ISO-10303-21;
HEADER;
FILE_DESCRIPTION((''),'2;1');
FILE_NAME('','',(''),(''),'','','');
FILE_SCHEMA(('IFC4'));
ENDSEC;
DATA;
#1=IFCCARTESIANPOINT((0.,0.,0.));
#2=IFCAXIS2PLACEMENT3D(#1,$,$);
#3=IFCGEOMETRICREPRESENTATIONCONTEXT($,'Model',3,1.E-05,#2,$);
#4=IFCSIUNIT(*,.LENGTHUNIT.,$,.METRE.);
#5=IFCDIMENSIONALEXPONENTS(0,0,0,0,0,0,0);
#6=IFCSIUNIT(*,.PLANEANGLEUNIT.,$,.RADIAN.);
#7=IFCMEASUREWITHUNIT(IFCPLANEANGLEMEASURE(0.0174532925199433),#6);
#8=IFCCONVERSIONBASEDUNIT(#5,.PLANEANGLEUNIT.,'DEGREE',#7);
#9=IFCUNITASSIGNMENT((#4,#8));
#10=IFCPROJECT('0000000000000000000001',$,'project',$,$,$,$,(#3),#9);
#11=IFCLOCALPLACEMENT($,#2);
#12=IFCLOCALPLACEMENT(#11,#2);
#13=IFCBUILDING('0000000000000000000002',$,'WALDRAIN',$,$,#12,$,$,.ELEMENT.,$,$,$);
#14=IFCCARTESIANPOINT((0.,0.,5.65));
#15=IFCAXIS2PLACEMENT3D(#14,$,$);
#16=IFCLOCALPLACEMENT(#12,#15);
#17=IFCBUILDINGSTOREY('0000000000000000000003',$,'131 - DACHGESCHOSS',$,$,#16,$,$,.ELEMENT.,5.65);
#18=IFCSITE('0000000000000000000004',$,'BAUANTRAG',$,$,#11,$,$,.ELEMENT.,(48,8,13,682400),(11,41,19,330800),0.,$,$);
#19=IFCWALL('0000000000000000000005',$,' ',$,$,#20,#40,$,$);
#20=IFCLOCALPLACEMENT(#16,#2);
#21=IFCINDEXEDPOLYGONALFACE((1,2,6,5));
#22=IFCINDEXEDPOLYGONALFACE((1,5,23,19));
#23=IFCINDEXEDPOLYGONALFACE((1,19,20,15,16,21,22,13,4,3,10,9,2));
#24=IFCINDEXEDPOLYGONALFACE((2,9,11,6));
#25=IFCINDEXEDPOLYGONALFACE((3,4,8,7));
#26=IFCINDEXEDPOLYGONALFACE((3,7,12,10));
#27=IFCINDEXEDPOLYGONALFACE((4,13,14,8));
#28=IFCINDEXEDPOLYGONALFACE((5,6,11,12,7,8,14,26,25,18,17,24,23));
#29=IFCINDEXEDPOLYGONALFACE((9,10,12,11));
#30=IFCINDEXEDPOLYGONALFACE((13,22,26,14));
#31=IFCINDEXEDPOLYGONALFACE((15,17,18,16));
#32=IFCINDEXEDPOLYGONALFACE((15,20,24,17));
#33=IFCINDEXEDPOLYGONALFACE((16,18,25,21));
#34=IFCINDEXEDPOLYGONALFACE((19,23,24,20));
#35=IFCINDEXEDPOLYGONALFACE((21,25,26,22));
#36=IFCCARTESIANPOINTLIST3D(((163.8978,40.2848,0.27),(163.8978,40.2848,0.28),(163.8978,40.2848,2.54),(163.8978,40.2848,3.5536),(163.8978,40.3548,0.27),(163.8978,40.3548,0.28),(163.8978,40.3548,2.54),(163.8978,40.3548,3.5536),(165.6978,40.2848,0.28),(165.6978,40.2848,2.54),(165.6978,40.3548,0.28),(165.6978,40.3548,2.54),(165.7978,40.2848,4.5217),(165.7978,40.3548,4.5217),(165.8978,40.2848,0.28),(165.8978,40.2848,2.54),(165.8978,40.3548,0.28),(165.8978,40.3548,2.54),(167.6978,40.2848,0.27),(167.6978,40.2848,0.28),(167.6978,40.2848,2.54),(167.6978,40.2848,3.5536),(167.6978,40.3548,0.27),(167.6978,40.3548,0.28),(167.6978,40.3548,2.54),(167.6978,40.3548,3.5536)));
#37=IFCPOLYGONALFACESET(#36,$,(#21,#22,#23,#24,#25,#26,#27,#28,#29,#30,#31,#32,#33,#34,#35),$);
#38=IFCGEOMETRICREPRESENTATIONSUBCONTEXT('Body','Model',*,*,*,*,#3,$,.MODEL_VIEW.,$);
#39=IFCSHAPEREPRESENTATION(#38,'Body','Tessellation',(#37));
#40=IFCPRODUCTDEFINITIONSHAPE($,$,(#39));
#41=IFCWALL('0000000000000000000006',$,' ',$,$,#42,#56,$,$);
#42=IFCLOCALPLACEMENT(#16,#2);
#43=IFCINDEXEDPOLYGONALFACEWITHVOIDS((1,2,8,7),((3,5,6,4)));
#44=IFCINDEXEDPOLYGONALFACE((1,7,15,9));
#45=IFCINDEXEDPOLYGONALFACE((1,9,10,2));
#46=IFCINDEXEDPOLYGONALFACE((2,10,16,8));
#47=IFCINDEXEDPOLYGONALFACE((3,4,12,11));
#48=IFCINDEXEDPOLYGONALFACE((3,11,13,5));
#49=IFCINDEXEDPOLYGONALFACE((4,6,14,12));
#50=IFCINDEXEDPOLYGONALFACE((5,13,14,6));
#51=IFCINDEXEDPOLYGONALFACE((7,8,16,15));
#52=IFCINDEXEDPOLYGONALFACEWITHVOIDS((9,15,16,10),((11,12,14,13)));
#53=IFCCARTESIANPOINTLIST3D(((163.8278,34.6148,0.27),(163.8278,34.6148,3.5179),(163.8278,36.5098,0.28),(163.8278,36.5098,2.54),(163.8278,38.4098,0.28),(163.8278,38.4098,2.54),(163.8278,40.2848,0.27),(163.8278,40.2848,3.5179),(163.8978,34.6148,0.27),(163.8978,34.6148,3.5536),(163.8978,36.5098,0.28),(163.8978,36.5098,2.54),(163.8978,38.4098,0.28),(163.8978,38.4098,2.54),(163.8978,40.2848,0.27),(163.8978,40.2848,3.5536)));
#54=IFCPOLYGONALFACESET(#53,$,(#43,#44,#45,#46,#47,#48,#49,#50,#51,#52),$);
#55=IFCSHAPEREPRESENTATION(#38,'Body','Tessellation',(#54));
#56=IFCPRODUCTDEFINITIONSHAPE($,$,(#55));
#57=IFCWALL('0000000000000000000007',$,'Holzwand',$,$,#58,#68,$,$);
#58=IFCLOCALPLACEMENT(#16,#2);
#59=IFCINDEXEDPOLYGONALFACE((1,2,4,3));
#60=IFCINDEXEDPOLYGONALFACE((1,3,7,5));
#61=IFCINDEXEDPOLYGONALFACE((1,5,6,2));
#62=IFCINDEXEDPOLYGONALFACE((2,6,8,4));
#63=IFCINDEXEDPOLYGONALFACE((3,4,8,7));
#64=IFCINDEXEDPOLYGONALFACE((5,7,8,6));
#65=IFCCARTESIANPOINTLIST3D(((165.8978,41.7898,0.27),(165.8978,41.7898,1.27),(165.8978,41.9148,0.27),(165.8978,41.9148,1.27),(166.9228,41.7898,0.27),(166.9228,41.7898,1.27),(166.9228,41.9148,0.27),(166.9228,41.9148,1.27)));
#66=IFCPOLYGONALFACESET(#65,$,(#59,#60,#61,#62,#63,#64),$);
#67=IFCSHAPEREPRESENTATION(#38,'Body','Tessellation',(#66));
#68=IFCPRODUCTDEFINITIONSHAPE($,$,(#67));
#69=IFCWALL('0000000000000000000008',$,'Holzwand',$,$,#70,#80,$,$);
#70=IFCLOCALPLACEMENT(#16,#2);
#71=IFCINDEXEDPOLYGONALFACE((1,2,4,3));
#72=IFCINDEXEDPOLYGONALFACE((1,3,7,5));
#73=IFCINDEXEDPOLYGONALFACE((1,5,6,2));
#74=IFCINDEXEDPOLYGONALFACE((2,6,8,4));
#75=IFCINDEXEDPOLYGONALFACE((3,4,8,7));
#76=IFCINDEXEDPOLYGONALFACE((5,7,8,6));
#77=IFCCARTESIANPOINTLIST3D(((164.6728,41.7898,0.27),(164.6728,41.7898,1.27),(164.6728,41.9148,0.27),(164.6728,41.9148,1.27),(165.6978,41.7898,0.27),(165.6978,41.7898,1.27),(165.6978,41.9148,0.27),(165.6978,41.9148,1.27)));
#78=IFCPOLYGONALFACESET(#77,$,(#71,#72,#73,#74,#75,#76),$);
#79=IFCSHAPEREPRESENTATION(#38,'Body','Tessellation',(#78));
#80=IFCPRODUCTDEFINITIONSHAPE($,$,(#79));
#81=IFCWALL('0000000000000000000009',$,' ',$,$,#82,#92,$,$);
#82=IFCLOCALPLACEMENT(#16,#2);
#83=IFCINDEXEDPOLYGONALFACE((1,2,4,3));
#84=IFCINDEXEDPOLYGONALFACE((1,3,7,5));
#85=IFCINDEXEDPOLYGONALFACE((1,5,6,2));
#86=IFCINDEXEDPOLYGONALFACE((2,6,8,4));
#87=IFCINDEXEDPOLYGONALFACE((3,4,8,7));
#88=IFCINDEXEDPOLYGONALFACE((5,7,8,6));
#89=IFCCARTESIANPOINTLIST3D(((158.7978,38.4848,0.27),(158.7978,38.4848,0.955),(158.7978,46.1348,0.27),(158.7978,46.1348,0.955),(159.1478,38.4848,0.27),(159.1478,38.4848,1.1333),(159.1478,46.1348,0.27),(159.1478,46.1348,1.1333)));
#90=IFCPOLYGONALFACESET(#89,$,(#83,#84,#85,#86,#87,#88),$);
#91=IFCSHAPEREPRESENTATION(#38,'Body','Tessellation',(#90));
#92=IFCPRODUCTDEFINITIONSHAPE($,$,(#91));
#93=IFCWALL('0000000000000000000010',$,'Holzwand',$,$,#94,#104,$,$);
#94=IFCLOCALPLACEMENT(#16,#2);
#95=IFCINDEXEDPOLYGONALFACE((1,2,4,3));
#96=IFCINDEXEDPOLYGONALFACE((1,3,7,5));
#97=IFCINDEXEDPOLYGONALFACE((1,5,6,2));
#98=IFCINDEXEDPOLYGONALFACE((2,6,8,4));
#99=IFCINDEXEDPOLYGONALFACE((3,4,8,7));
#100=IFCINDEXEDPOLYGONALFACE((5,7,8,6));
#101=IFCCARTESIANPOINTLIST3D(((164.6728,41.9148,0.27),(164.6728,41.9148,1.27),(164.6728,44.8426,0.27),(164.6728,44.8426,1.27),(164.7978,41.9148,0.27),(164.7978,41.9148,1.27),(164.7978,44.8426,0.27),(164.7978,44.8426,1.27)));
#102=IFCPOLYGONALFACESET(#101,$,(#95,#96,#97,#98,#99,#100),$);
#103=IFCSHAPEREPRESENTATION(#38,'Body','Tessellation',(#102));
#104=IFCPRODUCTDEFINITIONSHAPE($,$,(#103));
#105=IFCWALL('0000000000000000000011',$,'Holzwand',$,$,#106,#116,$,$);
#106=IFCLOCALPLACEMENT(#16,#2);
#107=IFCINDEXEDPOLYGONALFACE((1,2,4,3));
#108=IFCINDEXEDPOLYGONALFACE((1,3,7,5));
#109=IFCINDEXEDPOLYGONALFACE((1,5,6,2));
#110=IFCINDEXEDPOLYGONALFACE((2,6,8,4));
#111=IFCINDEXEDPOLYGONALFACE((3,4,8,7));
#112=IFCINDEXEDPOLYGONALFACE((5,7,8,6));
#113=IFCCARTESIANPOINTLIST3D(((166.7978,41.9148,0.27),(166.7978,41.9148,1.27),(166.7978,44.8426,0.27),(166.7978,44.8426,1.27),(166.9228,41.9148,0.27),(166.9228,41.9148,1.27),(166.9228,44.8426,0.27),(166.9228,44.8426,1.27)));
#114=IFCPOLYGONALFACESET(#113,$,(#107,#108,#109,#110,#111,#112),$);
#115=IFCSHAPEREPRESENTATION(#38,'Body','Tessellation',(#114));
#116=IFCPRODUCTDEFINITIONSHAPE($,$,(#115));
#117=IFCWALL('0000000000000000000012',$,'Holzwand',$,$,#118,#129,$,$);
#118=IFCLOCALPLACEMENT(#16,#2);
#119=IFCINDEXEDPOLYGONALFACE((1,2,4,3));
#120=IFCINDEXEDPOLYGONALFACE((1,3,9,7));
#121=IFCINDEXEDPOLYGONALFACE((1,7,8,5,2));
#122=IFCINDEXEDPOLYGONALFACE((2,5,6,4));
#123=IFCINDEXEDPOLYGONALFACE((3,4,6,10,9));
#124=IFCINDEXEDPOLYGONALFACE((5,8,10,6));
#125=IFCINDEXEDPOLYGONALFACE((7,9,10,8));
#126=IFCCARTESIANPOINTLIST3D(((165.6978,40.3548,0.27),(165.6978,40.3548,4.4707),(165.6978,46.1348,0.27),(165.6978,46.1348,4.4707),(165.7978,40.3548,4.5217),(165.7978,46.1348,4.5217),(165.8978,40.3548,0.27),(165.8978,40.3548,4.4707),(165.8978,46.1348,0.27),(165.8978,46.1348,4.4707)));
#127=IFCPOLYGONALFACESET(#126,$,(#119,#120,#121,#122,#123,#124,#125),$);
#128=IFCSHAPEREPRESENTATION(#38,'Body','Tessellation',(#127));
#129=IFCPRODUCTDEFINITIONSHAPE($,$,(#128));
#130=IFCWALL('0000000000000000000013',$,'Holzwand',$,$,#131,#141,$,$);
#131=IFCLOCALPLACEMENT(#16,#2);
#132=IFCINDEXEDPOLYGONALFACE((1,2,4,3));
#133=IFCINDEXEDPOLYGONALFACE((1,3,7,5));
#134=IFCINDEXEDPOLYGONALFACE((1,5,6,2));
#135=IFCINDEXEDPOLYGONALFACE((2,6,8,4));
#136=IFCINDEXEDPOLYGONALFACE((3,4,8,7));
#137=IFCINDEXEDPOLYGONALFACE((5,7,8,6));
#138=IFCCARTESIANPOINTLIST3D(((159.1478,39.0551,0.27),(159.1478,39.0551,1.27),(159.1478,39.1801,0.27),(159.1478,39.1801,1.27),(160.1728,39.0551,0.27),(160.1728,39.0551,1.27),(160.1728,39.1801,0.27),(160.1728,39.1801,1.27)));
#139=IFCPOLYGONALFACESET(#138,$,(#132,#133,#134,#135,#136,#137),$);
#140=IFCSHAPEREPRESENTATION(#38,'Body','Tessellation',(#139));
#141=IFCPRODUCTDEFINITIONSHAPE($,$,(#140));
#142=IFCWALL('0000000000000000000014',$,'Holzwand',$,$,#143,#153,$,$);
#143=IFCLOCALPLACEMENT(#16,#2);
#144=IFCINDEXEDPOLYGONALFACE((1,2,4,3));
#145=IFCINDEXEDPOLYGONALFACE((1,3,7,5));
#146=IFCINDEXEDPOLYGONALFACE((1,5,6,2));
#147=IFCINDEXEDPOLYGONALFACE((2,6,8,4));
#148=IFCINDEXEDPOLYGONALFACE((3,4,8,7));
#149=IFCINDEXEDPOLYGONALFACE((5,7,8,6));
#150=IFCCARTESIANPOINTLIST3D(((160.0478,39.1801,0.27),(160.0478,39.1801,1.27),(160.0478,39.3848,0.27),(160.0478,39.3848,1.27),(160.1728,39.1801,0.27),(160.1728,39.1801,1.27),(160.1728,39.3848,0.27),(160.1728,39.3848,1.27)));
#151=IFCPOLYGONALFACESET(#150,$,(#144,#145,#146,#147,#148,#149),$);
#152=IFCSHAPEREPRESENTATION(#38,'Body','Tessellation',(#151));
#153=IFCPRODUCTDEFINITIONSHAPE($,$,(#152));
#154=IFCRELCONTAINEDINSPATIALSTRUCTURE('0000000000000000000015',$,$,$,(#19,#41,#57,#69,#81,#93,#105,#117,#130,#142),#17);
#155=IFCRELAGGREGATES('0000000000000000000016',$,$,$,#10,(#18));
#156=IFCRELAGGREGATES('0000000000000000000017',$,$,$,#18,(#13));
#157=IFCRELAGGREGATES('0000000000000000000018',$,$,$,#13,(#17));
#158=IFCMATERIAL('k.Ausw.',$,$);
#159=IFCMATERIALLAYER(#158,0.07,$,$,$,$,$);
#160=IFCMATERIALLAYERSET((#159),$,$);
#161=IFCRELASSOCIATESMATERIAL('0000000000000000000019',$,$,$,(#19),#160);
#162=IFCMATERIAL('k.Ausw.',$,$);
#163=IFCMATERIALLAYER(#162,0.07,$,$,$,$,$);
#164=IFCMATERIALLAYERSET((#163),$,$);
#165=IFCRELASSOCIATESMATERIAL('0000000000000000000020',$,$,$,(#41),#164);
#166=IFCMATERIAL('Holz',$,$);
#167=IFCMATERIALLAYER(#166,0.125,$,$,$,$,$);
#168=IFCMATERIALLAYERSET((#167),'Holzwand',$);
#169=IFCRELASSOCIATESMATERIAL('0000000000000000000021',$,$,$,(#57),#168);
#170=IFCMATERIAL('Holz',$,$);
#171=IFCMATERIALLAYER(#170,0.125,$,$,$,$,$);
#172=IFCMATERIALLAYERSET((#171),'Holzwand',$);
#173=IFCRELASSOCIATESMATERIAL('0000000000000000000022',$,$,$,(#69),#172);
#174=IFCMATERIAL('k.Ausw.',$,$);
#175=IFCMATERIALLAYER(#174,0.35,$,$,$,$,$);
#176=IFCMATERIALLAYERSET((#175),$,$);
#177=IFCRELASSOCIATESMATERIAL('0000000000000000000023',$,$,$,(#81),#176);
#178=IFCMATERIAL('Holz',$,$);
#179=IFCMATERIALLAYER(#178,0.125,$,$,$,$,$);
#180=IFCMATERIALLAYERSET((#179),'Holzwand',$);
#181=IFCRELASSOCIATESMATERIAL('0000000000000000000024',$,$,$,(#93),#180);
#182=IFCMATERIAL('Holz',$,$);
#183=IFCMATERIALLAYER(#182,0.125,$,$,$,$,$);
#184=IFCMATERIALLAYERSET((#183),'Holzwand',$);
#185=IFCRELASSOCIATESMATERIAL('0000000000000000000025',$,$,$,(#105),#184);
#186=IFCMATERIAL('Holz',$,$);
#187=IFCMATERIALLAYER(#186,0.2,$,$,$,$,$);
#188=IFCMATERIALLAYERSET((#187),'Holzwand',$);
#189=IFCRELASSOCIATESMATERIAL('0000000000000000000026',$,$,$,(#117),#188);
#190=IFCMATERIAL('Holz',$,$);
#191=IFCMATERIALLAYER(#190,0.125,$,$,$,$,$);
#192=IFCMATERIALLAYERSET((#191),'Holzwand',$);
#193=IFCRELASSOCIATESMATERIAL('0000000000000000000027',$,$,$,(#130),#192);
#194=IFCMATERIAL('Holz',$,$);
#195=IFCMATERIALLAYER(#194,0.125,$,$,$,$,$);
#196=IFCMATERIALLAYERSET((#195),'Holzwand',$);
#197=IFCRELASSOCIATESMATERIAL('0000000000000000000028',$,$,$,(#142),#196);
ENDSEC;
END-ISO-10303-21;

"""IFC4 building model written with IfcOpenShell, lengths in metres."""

from ifc_helpers import new_model, entity, si_unit, converted_unit, frame, frame_2d, origin, origin_with_axes, place, context, subcontext, project, spatial, polyline, rectangle, outline, extrude, clip, halfspace, bounded_halfspace, material, layer, layer_set, layer_usage, element, save


model = new_model("IFC4")

# Units and contexts
model_context = context("Model", 3, precision=1e-05, world=origin())
body_context = subcontext(model_context, "Body", "Model", "MODEL_VIEW")
ifc_project = project(units=[si_unit("LENGTHUNIT", "METRE"), converted_unit("PLANEANGLEUNIT", "DEGREE", entity("IfcPlaneAngleMeasure", 0.0174532925199433), si_unit("PLANEANGLEUNIT", "RADIAN"), dimensions=[0, 0, 0, 0, 0, 0, 0])], contexts=[model_context])

# Site, building, storey
site_placement = place(None, origin())
site = spatial("IfcSite", under=ifc_project, at=site_placement, Name="BAUANTRAG", CompositionType="ELEMENT", RefLatitude=(48, 8, 13, 682400), RefLongitude=(11, 41, 19, 330800), RefElevation=0.0)
building_placement = place(site_placement, origin())
building = spatial("IfcBuilding", under=site, at=building_placement, Name="WALDRAIN", CompositionType="ELEMENT")
storey_placement = place(building_placement, frame((0.0, 0.0, 5.65)))
storey = spatial("IfcBuildingStorey", under=building, at=storey_placement, Name="131 - DACHGESCHOSS", CompositionType="ELEMENT", Elevation=5.65)

# Wall, openings
ifc_material_1 = material(Name="k.Ausw.")
ifc_layer_1 = layer(ifc_material_1, 0.07)
ifc_layer_set_1 = layer_set([ifc_layer_1])
ifc_layer_usage_1 = layer_usage(ifc_layer_set_1, "AXIS2", "POSITIVE", 0.0)
wall_1_placement = place(storey_placement, frame((167.6978, 40.3548, 0.27), z_axis=(0.0, 0.0, 1.0), x_axis=(-1.0, 0.0, 0.0)))
wall_1 = element("IfcWall", 1, at=wall_1_placement, inside=storey, material=ifc_layer_usage_1, Name=" ", context=body_context, shape_type="Clipping", body=[
    clip(clip(extrude(rectangle(XDim=3.8, YDim=0.07, at=frame_2d((1.9, 0.035), x_axis=(1.0, 0.0))), origin_with_axes(), (0.0, 0.0, 1.0), 4.2517), bounded_halfspace(frame((2.85, 0.035, 3.7676), z_axis=(-0.45399, 0.0, -0.891007), x_axis=(-0.891007, 0.0, 0.45399)), True, origin_with_axes(), polyline([(3.8, 0.07), (1.9, 0.07), (1.9, 0.0), (3.8, 0.0), (3.8, 0.07)]))), bounded_halfspace(frame((0.95, 0.035, 3.7676), z_axis=(0.45399, 0.0, -0.891007), x_axis=(0.891007, 0.0, 0.45399)), True, origin_with_axes(), polyline([(0.0, 0.0), (1.9, 0.0), (1.9, 0.07), (0.0, 0.07), (0.0, 0.0)]))),
])
opening_1_placement = place(wall_1_placement, frame((0.0, 0.0, 0.01), z_axis=(0.0, 1.0, 0.0), x_axis=(0.0, 0.0, 1.0)))
element("IfcOpeningElement", 2, at=opening_1_placement, cuts=wall_1, ObjectType="Opening", context=body_context, shape_type="SweptSolid", body=[
    extrude(outline(polyline([(0.0, 1.8), (2.26, 1.8), (2.26, 0.0), (0.0, 0.0), (0.0, 1.8)])), origin_with_axes(), (0.0, 0.0, 1.0), 0.07),
])
opening_2_placement = place(wall_1_placement, frame((2.0, 0.0, 0.01), z_axis=(0.0, 1.0, 0.0), x_axis=(0.0, 0.0, 1.0)))
element("IfcOpeningElement", 3, at=opening_2_placement, cuts=wall_1, ObjectType="Opening", context=body_context, shape_type="SweptSolid", body=[
    extrude(outline(polyline([(0.0, 1.8), (2.26, 1.8), (2.26, 0.0), (0.0, 0.0), (0.0, 1.8)])), origin_with_axes(), (0.0, 0.0, 1.0), 0.07),
])

# Wall, opening
ifc_material_2 = material(Name="k.Ausw.")
ifc_layer_2 = layer(ifc_material_2, 0.07)
ifc_layer_set_2 = layer_set([ifc_layer_2])
ifc_layer_usage_2 = layer_usage(ifc_layer_set_2, "AXIS2", "POSITIVE", 0.0)
wall_2_placement = place(storey_placement, frame((163.8278, 40.2848, 0.27), z_axis=(0.0, 0.0, 1.0), x_axis=(0.0, -1.0, 0.0)))
wall_2 = element("IfcWall", 4, at=wall_2_placement, inside=storey, material=ifc_layer_usage_2, Name=" ", context=body_context, shape_type="Clipping", body=[
    clip(extrude(rectangle(XDim=5.67, YDim=0.07, at=frame_2d((2.835, 0.035), x_axis=(1.0, 0.0))), origin_with_axes(), (0.0, 0.0, 1.0), 3.2836), halfspace(frame((2.835, 0.035, 3.2657), z_axis=(0.0, 0.45399, -0.891007), x_axis=(1.0, 0.0, 0.0)), True)),
])
opening_3_placement = place(wall_2_placement, frame((3.775, 0.07, 0.01), z_axis=(0.0, -1.0, 0.0), x_axis=(0.0, 0.0, 1.0)))
element("IfcOpeningElement", 5, at=opening_3_placement, cuts=wall_2, ObjectType="Opening", context=body_context, shape_type="SweptSolid", body=[
    extrude(outline(polyline([(0.0, 1.9), (2.26, 1.9), (2.26, 0.0), (0.0, 0.0), (0.0, 1.9)])), origin_with_axes(), (0.0, 0.0, 1.0), 0.07),
])

# Walls
ifc_material_3 = material(Name="Holz")
ifc_layer_3 = layer(ifc_material_3, 0.125)
ifc_layer_set_3 = layer_set([ifc_layer_3], Name="Holzwand")
ifc_layer_usage_3 = layer_usage(ifc_layer_set_3, "AXIS2", "POSITIVE", 0.0)
wall_3_placement = place(storey_placement, frame((166.9228, 41.9148, 0.27), z_axis=(0.0, 0.0, 1.0), x_axis=(-1.0, 0.0, 0.0)))
element("IfcWall", 6, at=wall_3_placement, inside=storey, material=ifc_layer_usage_3, Name="Holzwand", context=body_context, shape_type="SweptSolid", body=[
    extrude(rectangle(XDim=1.025, YDim=0.125, at=frame_2d((0.5125, 0.0625), x_axis=(1.0, 0.0))), origin_with_axes(), (0.0, 0.0, 1.0), 1.0),
])
ifc_material_4 = material(Name="Holz")
ifc_layer_4 = layer(ifc_material_4, 0.125)
ifc_layer_set_4 = layer_set([ifc_layer_4], Name="Holzwand")
ifc_layer_usage_4 = layer_usage(ifc_layer_set_4, "AXIS2", "POSITIVE", 0.0)
wall_4_placement = place(storey_placement, frame((165.6978, 41.9148, 0.27), z_axis=(0.0, 0.0, 1.0), x_axis=(-1.0, 0.0, 0.0)))
element("IfcWall", 7, at=wall_4_placement, inside=storey, material=ifc_layer_usage_4, Name="Holzwand", context=body_context, shape_type="SweptSolid", body=[
    extrude(rectangle(XDim=1.025, YDim=0.125, at=frame_2d((0.5125, 0.0625), x_axis=(1.0, 0.0))), origin_with_axes(), (0.0, 0.0, 1.0), 1.0),
])
ifc_material_5 = material(Name="k.Ausw.")
ifc_layer_5 = layer(ifc_material_5, 0.35)
ifc_layer_set_5 = layer_set([ifc_layer_5])
ifc_layer_usage_5 = layer_usage(ifc_layer_set_5, "AXIS2", "POSITIVE", 0.0)
wall_5_placement = place(storey_placement, frame((158.7978, 46.1348, 0.27), z_axis=(0.0, 0.0, 1.0), x_axis=(0.0, -1.0, 0.0)))
element("IfcWall", 8, at=wall_5_placement, inside=storey, material=ifc_layer_usage_5, Name=" ", context=body_context, shape_type="Clipping", body=[
    clip(extrude(rectangle(XDim=7.65, YDim=0.35, at=frame_2d((3.825, 0.175), x_axis=(1.0, 0.0))), origin_with_axes(), (0.0, 0.0, 1.0), 0.8633), halfspace(frame((3.825, 0.175, 0.7742), z_axis=(0.0, 0.45399, -0.891007), x_axis=(0.0, -0.891007, -0.45399)), True)),
])
ifc_material_6 = material(Name="Holz")
ifc_layer_6 = layer(ifc_material_6, 0.125)
ifc_layer_set_6 = layer_set([ifc_layer_6], Name="Holzwand")
ifc_layer_usage_6 = layer_usage(ifc_layer_set_6, "AXIS2", "POSITIVE", 0.0)
wall_6_placement = place(storey_placement, frame((164.7978, 41.9148, 0.27), z_axis=(0.0, 0.0, 1.0), x_axis=(0.0, 1.0, 0.0)))
element("IfcWall", 9, at=wall_6_placement, inside=storey, material=ifc_layer_usage_6, Name="Holzwand", context=body_context, shape_type="SweptSolid", body=[
    extrude(rectangle(XDim=2.9278, YDim=0.125, at=frame_2d((1.4639, 0.0625), x_axis=(1.0, 0.0))), origin_with_axes(), (0.0, 0.0, 1.0), 1.0),
])
ifc_material_7 = material(Name="Holz")
ifc_layer_7 = layer(ifc_material_7, 0.125)
ifc_layer_set_7 = layer_set([ifc_layer_7], Name="Holzwand")
ifc_layer_usage_7 = layer_usage(ifc_layer_set_7, "AXIS2", "POSITIVE", 0.0)
wall_7_placement = place(storey_placement, frame((166.7978, 44.8426, 0.27), z_axis=(0.0, 0.0, 1.0), x_axis=(0.0, -1.0, 0.0)))
element("IfcWall", 10, at=wall_7_placement, inside=storey, material=ifc_layer_usage_7, Name="Holzwand", context=body_context, shape_type="SweptSolid", body=[
    extrude(rectangle(XDim=2.9278, YDim=0.125, at=frame_2d((1.4639, 0.0625), x_axis=(1.0, 0.0))), origin_with_axes(), (0.0, 0.0, 1.0), 1.0),
])
ifc_material_8 = material(Name="Holz")
ifc_layer_8 = layer(ifc_material_8, 0.2)
ifc_layer_set_8 = layer_set([ifc_layer_8], Name="Holzwand")
ifc_layer_usage_8 = layer_usage(ifc_layer_set_8, "AXIS2", "POSITIVE", 0.0)
wall_8_placement = place(storey_placement, frame((165.6978, 46.1348, 0.27), z_axis=(0.0, 0.0, 1.0), x_axis=(0.0, -1.0, 0.0)))
element("IfcWall", 11, at=wall_8_placement, inside=storey, material=ifc_layer_usage_8, Name="Holzwand", context=body_context, shape_type="Clipping", body=[
    clip(clip(extrude(rectangle(XDim=5.78, YDim=0.2, at=frame_2d((2.89, 0.1), x_axis=(1.0, 0.0))), origin_with_axes(), (0.0, 0.0, 1.0), 4.2517), bounded_halfspace(frame((2.89, 0.05, 4.2262), z_axis=(0.0, 0.45399, -0.891007), x_axis=(0.0, 0.891007, 0.45399)), True, origin_with_axes(), polyline([(5.78, 0.0), (5.78, 0.1), (0.0, 0.1), (0.0, 0.0), (5.78, 0.0)]))), bounded_halfspace(frame((2.89, 0.15, 4.2262), z_axis=(0.0, -0.45399, -0.891007), x_axis=(0.0, -0.891007, 0.45399)), True, origin_with_axes(), polyline([(0.0, 0.2), (0.0, 0.1), (5.78, 0.1), (5.78, 0.2), (0.0, 0.2)]))),
])
ifc_material_9 = material(Name="Holz")
ifc_layer_9 = layer(ifc_material_9, 0.125)
ifc_layer_set_9 = layer_set([ifc_layer_9], Name="Holzwand")
ifc_layer_usage_9 = layer_usage(ifc_layer_set_9, "AXIS2", "POSITIVE", 0.0)
wall_9_placement = place(storey_placement, frame((160.1728, 39.1801, 0.27), z_axis=(0.0, 0.0, 1.0), x_axis=(-1.0, 0.0, 0.0)))
element("IfcWall", 12, at=wall_9_placement, inside=storey, material=ifc_layer_usage_9, Name="Holzwand", context=body_context, shape_type="SweptSolid", body=[
    extrude(rectangle(XDim=1.025, YDim=0.125, at=frame_2d((0.5125, 0.0625), x_axis=(1.0, 0.0))), origin_with_axes(), (0.0, 0.0, 1.0), 1.0),
])
ifc_material_10 = material(Name="Holz")
ifc_layer_10 = layer(ifc_material_10, 0.125)
ifc_layer_set_10 = layer_set([ifc_layer_10], Name="Holzwand")
ifc_layer_usage_10 = layer_usage(ifc_layer_set_10, "AXIS2", "POSITIVE", 0.0)
wall_10_placement = place(storey_placement, frame((160.0478, 39.3848, 0.27), z_axis=(0.0, 0.0, 1.0), x_axis=(0.0, -1.0, 0.0)))
element("IfcWall", 13, at=wall_10_placement, inside=storey, material=ifc_layer_usage_10, Name="Holzwand", context=body_context, shape_type="SweptSolid", body=[
    extrude(rectangle(XDim=0.2047, YDim=0.125, at=frame_2d((0.1024, 0.0625), x_axis=(1.0, 0.0))), origin_with_axes(), (0.0, 0.0, 1.0), 1.0),
])

save(model, "model.ifc")
